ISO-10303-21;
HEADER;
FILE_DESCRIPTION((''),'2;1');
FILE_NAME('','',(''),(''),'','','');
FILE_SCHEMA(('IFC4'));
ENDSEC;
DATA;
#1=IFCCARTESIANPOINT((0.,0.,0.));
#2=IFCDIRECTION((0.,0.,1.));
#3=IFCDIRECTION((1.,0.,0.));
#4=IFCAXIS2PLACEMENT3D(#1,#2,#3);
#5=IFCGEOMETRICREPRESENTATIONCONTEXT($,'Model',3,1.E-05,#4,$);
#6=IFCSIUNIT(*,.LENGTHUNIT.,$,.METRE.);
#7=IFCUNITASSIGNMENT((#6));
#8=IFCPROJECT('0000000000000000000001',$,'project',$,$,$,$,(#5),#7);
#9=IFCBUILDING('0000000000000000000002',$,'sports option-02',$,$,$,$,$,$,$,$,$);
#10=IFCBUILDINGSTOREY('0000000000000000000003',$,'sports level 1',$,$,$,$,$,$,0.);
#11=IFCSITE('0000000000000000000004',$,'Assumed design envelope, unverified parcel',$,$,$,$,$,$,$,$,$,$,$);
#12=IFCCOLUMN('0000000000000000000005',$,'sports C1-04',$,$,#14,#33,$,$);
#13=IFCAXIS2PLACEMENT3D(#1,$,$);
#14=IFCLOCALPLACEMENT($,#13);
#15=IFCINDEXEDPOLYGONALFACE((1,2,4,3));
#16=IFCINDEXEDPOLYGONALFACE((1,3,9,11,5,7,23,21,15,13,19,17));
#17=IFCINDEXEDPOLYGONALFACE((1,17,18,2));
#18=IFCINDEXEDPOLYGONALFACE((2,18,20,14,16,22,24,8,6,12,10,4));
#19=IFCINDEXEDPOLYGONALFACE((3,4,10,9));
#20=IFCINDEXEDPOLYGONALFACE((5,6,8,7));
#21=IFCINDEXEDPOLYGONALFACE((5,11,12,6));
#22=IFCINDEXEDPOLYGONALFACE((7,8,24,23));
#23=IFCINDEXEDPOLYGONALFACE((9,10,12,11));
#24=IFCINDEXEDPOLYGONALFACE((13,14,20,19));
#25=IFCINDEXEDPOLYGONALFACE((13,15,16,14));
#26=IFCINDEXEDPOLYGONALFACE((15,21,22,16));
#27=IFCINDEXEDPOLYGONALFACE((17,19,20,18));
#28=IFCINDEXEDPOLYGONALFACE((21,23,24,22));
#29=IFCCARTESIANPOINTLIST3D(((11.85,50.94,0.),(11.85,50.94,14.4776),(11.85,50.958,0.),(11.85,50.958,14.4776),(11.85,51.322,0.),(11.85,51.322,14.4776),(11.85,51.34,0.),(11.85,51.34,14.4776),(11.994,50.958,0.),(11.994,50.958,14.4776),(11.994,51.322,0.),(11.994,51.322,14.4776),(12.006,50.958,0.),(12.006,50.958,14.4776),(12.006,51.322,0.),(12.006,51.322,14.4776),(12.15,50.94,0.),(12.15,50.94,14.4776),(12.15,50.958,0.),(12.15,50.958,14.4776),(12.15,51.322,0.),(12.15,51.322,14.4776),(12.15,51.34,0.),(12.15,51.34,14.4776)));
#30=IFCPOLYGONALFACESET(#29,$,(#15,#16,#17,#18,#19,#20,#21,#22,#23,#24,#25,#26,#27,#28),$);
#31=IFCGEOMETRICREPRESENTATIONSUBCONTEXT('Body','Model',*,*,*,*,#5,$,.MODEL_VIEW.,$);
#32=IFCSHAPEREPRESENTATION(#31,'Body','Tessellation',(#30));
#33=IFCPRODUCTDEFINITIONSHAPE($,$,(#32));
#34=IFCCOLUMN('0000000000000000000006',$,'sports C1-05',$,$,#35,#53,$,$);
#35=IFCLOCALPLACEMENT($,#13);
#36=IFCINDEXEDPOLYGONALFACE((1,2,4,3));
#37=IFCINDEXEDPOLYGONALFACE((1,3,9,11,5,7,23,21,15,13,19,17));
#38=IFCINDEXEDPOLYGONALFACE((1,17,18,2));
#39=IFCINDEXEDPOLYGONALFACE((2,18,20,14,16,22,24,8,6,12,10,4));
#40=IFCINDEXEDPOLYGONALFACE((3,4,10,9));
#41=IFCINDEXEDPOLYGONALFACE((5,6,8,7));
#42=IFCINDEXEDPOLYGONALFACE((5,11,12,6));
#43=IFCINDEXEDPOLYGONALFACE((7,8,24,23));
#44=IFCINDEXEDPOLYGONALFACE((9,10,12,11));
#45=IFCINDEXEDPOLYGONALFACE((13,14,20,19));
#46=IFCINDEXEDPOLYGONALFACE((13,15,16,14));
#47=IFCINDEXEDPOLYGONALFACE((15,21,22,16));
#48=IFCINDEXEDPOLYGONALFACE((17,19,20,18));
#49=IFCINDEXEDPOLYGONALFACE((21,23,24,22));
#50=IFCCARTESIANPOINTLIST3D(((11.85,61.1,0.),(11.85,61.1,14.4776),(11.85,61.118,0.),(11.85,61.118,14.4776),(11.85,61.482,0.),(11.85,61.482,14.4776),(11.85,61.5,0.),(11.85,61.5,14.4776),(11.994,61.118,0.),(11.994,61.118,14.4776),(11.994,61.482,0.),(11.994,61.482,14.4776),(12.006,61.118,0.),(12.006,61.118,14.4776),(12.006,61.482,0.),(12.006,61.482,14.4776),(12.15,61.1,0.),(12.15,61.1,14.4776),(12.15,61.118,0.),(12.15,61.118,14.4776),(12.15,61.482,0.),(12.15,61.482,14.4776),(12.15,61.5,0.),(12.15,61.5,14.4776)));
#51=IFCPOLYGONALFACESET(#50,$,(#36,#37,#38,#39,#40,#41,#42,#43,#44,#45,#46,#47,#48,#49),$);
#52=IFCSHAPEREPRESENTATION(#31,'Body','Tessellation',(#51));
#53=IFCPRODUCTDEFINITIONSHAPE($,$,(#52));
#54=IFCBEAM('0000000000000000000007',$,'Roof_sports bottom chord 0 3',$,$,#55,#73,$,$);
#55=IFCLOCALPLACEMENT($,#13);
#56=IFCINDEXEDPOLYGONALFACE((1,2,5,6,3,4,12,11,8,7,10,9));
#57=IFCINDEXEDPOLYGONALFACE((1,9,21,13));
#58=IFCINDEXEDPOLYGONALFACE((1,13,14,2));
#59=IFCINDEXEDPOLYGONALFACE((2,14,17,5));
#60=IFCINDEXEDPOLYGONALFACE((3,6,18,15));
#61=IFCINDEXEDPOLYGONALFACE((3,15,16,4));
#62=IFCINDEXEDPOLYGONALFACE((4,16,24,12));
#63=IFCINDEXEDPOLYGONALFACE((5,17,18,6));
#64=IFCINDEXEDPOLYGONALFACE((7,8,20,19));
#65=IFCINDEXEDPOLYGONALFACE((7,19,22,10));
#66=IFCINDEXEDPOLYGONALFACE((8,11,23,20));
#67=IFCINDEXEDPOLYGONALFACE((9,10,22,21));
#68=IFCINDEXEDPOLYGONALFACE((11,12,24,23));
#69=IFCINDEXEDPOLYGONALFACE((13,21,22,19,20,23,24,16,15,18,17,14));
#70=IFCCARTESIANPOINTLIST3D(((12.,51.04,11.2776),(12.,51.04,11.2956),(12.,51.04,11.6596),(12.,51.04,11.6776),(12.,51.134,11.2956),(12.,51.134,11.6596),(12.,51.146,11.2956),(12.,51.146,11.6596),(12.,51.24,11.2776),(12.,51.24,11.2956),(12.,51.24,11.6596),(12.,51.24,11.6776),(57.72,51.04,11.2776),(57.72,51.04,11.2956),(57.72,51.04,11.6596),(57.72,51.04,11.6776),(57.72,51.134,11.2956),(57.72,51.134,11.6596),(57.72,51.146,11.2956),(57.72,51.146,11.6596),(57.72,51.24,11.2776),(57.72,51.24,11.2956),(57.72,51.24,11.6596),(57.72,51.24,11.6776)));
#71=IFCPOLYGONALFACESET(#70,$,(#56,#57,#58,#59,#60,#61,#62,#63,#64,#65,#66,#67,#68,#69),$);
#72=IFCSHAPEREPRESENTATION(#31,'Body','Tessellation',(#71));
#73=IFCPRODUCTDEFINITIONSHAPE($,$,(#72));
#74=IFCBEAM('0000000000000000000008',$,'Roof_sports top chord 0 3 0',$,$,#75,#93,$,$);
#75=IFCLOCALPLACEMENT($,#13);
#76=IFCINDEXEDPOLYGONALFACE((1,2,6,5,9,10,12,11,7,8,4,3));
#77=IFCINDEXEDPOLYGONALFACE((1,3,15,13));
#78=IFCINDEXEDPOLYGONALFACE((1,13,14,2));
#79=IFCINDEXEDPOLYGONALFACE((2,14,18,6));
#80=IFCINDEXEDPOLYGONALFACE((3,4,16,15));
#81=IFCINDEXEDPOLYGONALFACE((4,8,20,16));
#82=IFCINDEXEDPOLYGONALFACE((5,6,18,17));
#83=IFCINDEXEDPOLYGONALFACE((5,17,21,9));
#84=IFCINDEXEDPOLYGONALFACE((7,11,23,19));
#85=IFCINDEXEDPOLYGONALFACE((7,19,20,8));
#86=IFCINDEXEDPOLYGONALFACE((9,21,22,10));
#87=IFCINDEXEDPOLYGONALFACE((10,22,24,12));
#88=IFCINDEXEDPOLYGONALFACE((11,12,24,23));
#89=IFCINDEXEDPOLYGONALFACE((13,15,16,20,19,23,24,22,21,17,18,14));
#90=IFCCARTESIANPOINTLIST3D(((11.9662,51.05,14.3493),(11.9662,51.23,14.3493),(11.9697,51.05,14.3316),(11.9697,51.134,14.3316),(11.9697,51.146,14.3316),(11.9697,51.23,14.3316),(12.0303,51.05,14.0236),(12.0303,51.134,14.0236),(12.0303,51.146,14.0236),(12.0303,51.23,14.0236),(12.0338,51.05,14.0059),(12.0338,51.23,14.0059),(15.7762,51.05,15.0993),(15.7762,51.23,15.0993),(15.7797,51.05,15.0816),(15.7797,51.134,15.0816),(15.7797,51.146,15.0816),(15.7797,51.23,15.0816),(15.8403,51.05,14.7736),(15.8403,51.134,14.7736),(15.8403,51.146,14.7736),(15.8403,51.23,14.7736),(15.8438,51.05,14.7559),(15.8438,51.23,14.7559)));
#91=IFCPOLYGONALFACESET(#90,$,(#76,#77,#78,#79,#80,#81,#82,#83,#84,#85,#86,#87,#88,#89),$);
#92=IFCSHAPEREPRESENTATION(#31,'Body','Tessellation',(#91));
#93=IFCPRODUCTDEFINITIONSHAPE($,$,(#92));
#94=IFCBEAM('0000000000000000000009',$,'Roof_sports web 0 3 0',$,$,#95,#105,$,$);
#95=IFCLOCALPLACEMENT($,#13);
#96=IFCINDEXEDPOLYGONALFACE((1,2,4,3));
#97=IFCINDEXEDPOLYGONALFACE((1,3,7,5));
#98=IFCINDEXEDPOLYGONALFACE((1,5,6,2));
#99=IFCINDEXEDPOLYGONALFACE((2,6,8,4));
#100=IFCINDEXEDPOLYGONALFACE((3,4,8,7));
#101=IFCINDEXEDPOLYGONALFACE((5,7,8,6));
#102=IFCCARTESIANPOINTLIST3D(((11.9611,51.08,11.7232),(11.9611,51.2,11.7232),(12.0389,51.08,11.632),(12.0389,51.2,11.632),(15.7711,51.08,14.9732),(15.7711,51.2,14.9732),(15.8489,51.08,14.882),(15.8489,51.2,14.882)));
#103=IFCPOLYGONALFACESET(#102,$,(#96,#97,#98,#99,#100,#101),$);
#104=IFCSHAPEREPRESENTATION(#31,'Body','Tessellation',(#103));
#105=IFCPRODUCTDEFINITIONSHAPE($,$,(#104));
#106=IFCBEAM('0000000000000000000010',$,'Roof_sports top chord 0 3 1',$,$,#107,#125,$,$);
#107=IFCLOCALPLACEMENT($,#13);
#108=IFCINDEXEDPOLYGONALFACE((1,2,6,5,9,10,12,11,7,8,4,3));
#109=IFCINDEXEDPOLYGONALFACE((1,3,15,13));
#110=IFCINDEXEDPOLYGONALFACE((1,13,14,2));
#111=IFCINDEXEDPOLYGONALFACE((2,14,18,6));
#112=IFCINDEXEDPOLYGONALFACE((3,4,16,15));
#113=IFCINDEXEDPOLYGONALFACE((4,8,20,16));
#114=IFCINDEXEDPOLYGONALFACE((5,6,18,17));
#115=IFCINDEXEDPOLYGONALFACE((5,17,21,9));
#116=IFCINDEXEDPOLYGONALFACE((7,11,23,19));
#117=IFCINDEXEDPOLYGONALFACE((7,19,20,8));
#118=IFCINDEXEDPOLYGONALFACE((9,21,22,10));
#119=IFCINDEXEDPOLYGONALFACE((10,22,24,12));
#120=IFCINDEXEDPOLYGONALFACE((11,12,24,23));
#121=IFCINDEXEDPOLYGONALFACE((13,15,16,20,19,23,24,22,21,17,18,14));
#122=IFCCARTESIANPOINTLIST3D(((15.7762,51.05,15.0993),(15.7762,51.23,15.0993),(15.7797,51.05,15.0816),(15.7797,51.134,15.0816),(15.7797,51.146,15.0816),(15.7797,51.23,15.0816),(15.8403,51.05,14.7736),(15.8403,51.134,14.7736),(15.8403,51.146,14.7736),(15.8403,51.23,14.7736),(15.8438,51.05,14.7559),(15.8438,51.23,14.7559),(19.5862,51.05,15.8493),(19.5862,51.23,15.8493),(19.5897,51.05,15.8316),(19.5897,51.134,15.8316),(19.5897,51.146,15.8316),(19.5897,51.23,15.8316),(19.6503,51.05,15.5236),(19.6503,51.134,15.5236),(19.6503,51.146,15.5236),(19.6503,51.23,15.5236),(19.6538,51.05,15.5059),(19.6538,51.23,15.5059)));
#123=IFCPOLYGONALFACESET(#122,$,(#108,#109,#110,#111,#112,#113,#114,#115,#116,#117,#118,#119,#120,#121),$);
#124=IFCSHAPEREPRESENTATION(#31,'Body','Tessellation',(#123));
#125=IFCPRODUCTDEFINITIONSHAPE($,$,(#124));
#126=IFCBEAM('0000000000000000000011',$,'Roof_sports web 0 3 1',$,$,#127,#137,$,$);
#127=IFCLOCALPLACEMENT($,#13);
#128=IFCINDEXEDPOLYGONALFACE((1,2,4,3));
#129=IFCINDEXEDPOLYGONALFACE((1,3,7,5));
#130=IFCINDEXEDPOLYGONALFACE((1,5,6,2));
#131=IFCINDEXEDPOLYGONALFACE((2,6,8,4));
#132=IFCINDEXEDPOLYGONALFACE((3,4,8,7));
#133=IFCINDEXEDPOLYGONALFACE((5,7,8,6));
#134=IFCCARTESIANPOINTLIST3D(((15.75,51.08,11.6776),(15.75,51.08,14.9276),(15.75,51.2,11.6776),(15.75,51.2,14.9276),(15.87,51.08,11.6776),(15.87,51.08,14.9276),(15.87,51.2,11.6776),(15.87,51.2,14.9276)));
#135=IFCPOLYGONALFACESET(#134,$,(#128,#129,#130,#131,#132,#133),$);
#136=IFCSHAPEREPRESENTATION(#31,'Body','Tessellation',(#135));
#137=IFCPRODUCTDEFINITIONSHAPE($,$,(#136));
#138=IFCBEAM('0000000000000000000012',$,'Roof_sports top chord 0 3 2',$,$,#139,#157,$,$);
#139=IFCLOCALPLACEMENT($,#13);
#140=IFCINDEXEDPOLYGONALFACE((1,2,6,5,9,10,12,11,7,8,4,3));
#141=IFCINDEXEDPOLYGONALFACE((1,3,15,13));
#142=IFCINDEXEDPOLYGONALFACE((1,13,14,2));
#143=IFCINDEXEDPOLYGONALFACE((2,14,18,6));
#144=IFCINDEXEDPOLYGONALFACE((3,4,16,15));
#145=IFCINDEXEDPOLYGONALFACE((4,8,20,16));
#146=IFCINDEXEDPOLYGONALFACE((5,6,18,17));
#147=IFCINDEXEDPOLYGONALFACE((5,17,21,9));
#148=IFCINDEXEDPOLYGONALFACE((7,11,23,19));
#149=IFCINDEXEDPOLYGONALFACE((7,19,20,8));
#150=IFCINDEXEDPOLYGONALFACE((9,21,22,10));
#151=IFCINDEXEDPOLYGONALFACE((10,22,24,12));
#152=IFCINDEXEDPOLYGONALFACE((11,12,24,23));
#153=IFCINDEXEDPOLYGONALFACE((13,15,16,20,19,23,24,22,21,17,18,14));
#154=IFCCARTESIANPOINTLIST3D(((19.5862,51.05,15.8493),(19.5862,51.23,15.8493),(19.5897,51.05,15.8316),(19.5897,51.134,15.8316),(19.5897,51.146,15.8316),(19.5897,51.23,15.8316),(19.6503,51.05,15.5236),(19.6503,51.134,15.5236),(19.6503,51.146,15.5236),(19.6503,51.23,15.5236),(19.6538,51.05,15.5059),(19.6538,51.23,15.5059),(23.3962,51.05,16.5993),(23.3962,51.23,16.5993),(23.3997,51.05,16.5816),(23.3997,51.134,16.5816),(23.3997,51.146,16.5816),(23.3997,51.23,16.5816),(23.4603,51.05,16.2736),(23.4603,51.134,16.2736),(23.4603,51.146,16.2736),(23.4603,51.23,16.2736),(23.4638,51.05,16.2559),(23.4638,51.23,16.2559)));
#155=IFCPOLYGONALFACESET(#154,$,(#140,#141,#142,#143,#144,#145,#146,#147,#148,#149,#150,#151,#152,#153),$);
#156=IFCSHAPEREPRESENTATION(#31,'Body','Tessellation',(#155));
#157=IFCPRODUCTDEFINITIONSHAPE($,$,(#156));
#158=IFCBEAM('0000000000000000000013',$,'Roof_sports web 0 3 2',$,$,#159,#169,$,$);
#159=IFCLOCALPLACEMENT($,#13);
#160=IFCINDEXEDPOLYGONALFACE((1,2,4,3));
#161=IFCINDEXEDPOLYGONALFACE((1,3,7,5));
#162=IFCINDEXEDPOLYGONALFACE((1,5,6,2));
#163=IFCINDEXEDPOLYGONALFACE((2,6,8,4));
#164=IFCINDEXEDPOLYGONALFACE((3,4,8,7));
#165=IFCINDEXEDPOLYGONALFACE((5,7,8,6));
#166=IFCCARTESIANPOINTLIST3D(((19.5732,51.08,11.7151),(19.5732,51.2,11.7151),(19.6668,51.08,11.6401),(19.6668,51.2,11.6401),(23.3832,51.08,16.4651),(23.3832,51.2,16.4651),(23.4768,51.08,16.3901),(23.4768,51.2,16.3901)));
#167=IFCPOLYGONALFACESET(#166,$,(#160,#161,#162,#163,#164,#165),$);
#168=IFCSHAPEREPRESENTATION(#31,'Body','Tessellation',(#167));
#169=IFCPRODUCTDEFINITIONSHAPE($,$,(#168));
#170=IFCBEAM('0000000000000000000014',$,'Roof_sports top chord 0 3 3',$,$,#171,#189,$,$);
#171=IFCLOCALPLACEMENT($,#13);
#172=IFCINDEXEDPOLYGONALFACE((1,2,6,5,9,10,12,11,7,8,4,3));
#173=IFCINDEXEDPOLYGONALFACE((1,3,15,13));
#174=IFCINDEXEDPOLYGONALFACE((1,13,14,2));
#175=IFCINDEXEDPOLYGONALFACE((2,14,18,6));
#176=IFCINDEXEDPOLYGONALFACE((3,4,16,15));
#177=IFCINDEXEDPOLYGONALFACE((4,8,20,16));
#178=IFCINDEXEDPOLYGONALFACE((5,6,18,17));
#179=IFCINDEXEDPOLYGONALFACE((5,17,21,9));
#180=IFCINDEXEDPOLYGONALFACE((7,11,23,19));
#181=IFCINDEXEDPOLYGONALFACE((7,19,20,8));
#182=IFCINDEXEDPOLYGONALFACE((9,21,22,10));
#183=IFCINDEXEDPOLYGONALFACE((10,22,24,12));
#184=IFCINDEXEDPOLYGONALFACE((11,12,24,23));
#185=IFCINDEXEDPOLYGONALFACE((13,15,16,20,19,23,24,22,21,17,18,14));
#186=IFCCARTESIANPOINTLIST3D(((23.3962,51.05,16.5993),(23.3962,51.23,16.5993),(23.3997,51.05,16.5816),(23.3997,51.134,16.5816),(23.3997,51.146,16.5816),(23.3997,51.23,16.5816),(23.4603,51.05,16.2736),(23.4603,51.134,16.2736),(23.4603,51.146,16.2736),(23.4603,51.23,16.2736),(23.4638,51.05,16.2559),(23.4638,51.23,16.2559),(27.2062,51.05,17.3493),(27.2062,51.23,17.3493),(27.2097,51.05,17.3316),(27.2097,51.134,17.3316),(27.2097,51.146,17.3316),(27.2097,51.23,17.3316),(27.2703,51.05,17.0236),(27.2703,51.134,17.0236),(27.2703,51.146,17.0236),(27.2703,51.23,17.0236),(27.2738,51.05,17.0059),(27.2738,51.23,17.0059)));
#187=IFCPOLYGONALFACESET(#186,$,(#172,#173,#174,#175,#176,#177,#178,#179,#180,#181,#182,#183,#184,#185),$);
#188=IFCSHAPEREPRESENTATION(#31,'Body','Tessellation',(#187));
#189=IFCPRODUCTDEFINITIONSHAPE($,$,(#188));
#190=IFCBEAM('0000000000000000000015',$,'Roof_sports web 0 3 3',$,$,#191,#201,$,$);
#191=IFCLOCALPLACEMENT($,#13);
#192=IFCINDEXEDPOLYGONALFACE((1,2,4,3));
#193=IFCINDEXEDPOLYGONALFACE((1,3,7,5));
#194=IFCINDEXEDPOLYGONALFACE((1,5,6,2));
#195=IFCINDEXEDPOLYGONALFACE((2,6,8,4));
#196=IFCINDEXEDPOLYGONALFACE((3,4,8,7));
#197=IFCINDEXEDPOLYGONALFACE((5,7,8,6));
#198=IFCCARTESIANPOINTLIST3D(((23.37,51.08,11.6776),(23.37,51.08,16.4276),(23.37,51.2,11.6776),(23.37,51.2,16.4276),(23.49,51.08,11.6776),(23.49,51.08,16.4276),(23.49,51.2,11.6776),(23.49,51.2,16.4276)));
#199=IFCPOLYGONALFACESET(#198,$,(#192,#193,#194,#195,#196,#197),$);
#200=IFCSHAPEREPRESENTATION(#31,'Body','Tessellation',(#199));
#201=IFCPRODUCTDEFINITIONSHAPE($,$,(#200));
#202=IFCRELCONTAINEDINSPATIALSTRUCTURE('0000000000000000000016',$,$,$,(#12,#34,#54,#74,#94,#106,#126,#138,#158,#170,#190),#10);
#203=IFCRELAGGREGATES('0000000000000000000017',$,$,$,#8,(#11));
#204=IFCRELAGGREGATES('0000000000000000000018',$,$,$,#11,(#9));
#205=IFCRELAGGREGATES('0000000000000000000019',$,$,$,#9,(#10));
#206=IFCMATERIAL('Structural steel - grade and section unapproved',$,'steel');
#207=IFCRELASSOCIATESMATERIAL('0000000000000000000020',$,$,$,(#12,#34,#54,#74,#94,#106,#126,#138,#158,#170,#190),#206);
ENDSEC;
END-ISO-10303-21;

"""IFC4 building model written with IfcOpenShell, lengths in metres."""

from ifc_helpers import new_model, si_unit, frame, origin_with_axes, place, context, subcontext, project, spatial, rectangle, i_section, extrude, material, element, save


model = new_model("IFC4")

# Units and contexts
model_context = context("Model", 3, precision=1e-05, world=origin_with_axes())
body_context = subcontext(model_context, "Body", "Model", "MODEL_VIEW")
ifc_project = project(units=[si_unit("LENGTHUNIT", "METRE")], contexts=[model_context])

# Site, building, storey
site = spatial("IfcSite", under=ifc_project, Name="Assumed design envelope, unverified parcel")
building = spatial("IfcBuilding", under=site, Name="sports option-02")
storey = spatial("IfcBuildingStorey", under=building, Name="sports level 1", Elevation=0.0)

# Columns
ifc_material_1 = material(Name="Structural steel - grade and section unapproved", Category="steel")
for number, where, z_axis, x_axis, name in (
    (1, (12.0, 51.14, 0.0), (0.0, 0.0, 1.0), (-1.0, 0.0, 0.0), "sports C1-04"),
    (2, (12.0, 61.3, 0.0), (0.0, 0.0, 1.0), (-1.0, 0.0, 0.0), "sports C1-05"),
):
    element("IfcColumn", number, at=place(None, frame(where, z_axis=z_axis, x_axis=x_axis)), inside=storey, material=ifc_material_1, Name=name, context=body_context, shape_type="SweptSolid", body=[
        extrude(i_section(OverallWidth=0.3, OverallDepth=0.4, WebThickness=0.012, FlangeThickness=0.018, FilletRadius=0.0), origin_with_axes(), (0.0, 0.0, 1.0), 14.4776),
    ])

# Beams
beam_1_placement = place(None, frame((12.0, 51.14, 11.4776), z_axis=(1.0, 0.0, 0.0), x_axis=(0.0, 1.0, 0.0)))
element("IfcBeam", 3, at=beam_1_placement, inside=storey, material=ifc_material_1, Name="Roof_sports bottom chord 0 3", context=body_context, shape_type="SweptSolid", body=[
    extrude(i_section(OverallWidth=0.2, OverallDepth=0.4, WebThickness=0.012, FlangeThickness=0.018, FilletRadius=0.0), origin_with_axes(), (0.0, 0.0, 1.0), 45.72),
])
beam_2_placement = place(None, frame((12.0, 51.14, 14.1776), z_axis=(0.981171, 0.0, 0.193144), x_axis=(0.0, 1.0, 0.0)))
element("IfcBeam", 4, at=beam_2_placement, inside=storey, material=ifc_material_1, Name="Roof_sports top chord 0 3 0", context=body_context, shape_type="SweptSolid", body=[
    extrude(i_section(OverallWidth=0.18, OverallDepth=0.35, WebThickness=0.012, FlangeThickness=0.018, FilletRadius=0.0), origin_with_axes(), (0.0, 0.0, 1.0), 3.8831),
])
beam_3_placement = place(None, frame((12.0, 51.14, 11.6776), z_axis=(0.760805, 0.0, 0.648981), x_axis=(0.0, 1.0, 0.0)))
element("IfcBeam", 5, at=beam_3_placement, inside=storey, material=ifc_material_1, Name="Roof_sports web 0 3 0", context=body_context, shape_type="SweptSolid", body=[
    extrude(rectangle(XDim=0.12, YDim=0.12), origin_with_axes(), (0.0, 0.0, 1.0), 5.0079),
])
beam_4_placement = place(None, frame((15.81, 51.14, 14.9276), z_axis=(0.981171, 0.0, 0.193144), x_axis=(0.0, 1.0, 0.0)))
element("IfcBeam", 6, at=beam_4_placement, inside=storey, material=ifc_material_1, Name="Roof_sports top chord 0 3 1", context=body_context, shape_type="SweptSolid", body=[
    extrude(i_section(OverallWidth=0.18, OverallDepth=0.35, WebThickness=0.012, FlangeThickness=0.018, FilletRadius=0.0), origin_with_axes(), (0.0, 0.0, 1.0), 3.8831),
])
beam_5_placement = place(None, frame((15.81, 51.14, 11.6776), z_axis=(0.0, 0.0, 1.0), x_axis=(-1.0, 0.0, 0.0)))
element("IfcBeam", 7, at=beam_5_placement, inside=storey, material=ifc_material_1, Name="Roof_sports web 0 3 1", context=body_context, shape_type="SweptSolid", body=[
    extrude(rectangle(XDim=0.12, YDim=0.12), origin_with_axes(), (0.0, 0.0, 1.0), 3.25),
])
beam_6_placement = place(None, frame((19.62, 51.14, 15.6776), z_axis=(0.98117, 0.0, 0.193144), x_axis=(0.0, 1.0, 0.0)))
element("IfcBeam", 8, at=beam_6_placement, inside=storey, material=ifc_material_1, Name="Roof_sports top chord 0 3 2", context=body_context, shape_type="SweptSolid", body=[
    extrude(i_section(OverallWidth=0.18, OverallDepth=0.35, WebThickness=0.012, FlangeThickness=0.018, FilletRadius=0.0), origin_with_axes(), (0.0, 0.0, 1.0), 3.8831),
])
beam_7_placement = place(None, frame((19.62, 51.14, 11.6776), z_axis=(0.625696, 0.0, 0.780067), x_axis=(0.0, 1.0, 0.0)))
element("IfcBeam", 9, at=beam_7_placement, inside=storey, material=ifc_material_1, Name="Roof_sports web 0 3 2", context=body_context, shape_type="SweptSolid", body=[
    extrude(rectangle(XDim=0.12, YDim=0.12), origin_with_axes(), (0.0, 0.0, 1.0), 6.0892),
])
beam_8_placement = place(None, frame((23.43, 51.14, 16.4276), z_axis=(0.981171, 0.0, 0.193143), x_axis=(0.0, 1.0, 0.0)))
element("IfcBeam", 10, at=beam_8_placement, inside=storey, material=ifc_material_1, Name="Roof_sports top chord 0 3 3", context=body_context, shape_type="SweptSolid", body=[
    extrude(i_section(OverallWidth=0.18, OverallDepth=0.35, WebThickness=0.012, FlangeThickness=0.018, FilletRadius=0.0), origin_with_axes(), (0.0, 0.0, 1.0), 3.8831),
])
beam_9_placement = place(None, frame((23.43, 51.14, 11.6776), z_axis=(0.0, 0.0, 1.0), x_axis=(-1.0, 0.0, 0.0)))
element("IfcBeam", 11, at=beam_9_placement, inside=storey, material=ifc_material_1, Name="Roof_sports web 0 3 3", context=body_context, shape_type="SweptSolid", body=[
    extrude(rectangle(XDim=0.12, YDim=0.12), origin_with_axes(), (0.0, 0.0, 1.0), 4.75),
])

save(model, "model.ifc")
